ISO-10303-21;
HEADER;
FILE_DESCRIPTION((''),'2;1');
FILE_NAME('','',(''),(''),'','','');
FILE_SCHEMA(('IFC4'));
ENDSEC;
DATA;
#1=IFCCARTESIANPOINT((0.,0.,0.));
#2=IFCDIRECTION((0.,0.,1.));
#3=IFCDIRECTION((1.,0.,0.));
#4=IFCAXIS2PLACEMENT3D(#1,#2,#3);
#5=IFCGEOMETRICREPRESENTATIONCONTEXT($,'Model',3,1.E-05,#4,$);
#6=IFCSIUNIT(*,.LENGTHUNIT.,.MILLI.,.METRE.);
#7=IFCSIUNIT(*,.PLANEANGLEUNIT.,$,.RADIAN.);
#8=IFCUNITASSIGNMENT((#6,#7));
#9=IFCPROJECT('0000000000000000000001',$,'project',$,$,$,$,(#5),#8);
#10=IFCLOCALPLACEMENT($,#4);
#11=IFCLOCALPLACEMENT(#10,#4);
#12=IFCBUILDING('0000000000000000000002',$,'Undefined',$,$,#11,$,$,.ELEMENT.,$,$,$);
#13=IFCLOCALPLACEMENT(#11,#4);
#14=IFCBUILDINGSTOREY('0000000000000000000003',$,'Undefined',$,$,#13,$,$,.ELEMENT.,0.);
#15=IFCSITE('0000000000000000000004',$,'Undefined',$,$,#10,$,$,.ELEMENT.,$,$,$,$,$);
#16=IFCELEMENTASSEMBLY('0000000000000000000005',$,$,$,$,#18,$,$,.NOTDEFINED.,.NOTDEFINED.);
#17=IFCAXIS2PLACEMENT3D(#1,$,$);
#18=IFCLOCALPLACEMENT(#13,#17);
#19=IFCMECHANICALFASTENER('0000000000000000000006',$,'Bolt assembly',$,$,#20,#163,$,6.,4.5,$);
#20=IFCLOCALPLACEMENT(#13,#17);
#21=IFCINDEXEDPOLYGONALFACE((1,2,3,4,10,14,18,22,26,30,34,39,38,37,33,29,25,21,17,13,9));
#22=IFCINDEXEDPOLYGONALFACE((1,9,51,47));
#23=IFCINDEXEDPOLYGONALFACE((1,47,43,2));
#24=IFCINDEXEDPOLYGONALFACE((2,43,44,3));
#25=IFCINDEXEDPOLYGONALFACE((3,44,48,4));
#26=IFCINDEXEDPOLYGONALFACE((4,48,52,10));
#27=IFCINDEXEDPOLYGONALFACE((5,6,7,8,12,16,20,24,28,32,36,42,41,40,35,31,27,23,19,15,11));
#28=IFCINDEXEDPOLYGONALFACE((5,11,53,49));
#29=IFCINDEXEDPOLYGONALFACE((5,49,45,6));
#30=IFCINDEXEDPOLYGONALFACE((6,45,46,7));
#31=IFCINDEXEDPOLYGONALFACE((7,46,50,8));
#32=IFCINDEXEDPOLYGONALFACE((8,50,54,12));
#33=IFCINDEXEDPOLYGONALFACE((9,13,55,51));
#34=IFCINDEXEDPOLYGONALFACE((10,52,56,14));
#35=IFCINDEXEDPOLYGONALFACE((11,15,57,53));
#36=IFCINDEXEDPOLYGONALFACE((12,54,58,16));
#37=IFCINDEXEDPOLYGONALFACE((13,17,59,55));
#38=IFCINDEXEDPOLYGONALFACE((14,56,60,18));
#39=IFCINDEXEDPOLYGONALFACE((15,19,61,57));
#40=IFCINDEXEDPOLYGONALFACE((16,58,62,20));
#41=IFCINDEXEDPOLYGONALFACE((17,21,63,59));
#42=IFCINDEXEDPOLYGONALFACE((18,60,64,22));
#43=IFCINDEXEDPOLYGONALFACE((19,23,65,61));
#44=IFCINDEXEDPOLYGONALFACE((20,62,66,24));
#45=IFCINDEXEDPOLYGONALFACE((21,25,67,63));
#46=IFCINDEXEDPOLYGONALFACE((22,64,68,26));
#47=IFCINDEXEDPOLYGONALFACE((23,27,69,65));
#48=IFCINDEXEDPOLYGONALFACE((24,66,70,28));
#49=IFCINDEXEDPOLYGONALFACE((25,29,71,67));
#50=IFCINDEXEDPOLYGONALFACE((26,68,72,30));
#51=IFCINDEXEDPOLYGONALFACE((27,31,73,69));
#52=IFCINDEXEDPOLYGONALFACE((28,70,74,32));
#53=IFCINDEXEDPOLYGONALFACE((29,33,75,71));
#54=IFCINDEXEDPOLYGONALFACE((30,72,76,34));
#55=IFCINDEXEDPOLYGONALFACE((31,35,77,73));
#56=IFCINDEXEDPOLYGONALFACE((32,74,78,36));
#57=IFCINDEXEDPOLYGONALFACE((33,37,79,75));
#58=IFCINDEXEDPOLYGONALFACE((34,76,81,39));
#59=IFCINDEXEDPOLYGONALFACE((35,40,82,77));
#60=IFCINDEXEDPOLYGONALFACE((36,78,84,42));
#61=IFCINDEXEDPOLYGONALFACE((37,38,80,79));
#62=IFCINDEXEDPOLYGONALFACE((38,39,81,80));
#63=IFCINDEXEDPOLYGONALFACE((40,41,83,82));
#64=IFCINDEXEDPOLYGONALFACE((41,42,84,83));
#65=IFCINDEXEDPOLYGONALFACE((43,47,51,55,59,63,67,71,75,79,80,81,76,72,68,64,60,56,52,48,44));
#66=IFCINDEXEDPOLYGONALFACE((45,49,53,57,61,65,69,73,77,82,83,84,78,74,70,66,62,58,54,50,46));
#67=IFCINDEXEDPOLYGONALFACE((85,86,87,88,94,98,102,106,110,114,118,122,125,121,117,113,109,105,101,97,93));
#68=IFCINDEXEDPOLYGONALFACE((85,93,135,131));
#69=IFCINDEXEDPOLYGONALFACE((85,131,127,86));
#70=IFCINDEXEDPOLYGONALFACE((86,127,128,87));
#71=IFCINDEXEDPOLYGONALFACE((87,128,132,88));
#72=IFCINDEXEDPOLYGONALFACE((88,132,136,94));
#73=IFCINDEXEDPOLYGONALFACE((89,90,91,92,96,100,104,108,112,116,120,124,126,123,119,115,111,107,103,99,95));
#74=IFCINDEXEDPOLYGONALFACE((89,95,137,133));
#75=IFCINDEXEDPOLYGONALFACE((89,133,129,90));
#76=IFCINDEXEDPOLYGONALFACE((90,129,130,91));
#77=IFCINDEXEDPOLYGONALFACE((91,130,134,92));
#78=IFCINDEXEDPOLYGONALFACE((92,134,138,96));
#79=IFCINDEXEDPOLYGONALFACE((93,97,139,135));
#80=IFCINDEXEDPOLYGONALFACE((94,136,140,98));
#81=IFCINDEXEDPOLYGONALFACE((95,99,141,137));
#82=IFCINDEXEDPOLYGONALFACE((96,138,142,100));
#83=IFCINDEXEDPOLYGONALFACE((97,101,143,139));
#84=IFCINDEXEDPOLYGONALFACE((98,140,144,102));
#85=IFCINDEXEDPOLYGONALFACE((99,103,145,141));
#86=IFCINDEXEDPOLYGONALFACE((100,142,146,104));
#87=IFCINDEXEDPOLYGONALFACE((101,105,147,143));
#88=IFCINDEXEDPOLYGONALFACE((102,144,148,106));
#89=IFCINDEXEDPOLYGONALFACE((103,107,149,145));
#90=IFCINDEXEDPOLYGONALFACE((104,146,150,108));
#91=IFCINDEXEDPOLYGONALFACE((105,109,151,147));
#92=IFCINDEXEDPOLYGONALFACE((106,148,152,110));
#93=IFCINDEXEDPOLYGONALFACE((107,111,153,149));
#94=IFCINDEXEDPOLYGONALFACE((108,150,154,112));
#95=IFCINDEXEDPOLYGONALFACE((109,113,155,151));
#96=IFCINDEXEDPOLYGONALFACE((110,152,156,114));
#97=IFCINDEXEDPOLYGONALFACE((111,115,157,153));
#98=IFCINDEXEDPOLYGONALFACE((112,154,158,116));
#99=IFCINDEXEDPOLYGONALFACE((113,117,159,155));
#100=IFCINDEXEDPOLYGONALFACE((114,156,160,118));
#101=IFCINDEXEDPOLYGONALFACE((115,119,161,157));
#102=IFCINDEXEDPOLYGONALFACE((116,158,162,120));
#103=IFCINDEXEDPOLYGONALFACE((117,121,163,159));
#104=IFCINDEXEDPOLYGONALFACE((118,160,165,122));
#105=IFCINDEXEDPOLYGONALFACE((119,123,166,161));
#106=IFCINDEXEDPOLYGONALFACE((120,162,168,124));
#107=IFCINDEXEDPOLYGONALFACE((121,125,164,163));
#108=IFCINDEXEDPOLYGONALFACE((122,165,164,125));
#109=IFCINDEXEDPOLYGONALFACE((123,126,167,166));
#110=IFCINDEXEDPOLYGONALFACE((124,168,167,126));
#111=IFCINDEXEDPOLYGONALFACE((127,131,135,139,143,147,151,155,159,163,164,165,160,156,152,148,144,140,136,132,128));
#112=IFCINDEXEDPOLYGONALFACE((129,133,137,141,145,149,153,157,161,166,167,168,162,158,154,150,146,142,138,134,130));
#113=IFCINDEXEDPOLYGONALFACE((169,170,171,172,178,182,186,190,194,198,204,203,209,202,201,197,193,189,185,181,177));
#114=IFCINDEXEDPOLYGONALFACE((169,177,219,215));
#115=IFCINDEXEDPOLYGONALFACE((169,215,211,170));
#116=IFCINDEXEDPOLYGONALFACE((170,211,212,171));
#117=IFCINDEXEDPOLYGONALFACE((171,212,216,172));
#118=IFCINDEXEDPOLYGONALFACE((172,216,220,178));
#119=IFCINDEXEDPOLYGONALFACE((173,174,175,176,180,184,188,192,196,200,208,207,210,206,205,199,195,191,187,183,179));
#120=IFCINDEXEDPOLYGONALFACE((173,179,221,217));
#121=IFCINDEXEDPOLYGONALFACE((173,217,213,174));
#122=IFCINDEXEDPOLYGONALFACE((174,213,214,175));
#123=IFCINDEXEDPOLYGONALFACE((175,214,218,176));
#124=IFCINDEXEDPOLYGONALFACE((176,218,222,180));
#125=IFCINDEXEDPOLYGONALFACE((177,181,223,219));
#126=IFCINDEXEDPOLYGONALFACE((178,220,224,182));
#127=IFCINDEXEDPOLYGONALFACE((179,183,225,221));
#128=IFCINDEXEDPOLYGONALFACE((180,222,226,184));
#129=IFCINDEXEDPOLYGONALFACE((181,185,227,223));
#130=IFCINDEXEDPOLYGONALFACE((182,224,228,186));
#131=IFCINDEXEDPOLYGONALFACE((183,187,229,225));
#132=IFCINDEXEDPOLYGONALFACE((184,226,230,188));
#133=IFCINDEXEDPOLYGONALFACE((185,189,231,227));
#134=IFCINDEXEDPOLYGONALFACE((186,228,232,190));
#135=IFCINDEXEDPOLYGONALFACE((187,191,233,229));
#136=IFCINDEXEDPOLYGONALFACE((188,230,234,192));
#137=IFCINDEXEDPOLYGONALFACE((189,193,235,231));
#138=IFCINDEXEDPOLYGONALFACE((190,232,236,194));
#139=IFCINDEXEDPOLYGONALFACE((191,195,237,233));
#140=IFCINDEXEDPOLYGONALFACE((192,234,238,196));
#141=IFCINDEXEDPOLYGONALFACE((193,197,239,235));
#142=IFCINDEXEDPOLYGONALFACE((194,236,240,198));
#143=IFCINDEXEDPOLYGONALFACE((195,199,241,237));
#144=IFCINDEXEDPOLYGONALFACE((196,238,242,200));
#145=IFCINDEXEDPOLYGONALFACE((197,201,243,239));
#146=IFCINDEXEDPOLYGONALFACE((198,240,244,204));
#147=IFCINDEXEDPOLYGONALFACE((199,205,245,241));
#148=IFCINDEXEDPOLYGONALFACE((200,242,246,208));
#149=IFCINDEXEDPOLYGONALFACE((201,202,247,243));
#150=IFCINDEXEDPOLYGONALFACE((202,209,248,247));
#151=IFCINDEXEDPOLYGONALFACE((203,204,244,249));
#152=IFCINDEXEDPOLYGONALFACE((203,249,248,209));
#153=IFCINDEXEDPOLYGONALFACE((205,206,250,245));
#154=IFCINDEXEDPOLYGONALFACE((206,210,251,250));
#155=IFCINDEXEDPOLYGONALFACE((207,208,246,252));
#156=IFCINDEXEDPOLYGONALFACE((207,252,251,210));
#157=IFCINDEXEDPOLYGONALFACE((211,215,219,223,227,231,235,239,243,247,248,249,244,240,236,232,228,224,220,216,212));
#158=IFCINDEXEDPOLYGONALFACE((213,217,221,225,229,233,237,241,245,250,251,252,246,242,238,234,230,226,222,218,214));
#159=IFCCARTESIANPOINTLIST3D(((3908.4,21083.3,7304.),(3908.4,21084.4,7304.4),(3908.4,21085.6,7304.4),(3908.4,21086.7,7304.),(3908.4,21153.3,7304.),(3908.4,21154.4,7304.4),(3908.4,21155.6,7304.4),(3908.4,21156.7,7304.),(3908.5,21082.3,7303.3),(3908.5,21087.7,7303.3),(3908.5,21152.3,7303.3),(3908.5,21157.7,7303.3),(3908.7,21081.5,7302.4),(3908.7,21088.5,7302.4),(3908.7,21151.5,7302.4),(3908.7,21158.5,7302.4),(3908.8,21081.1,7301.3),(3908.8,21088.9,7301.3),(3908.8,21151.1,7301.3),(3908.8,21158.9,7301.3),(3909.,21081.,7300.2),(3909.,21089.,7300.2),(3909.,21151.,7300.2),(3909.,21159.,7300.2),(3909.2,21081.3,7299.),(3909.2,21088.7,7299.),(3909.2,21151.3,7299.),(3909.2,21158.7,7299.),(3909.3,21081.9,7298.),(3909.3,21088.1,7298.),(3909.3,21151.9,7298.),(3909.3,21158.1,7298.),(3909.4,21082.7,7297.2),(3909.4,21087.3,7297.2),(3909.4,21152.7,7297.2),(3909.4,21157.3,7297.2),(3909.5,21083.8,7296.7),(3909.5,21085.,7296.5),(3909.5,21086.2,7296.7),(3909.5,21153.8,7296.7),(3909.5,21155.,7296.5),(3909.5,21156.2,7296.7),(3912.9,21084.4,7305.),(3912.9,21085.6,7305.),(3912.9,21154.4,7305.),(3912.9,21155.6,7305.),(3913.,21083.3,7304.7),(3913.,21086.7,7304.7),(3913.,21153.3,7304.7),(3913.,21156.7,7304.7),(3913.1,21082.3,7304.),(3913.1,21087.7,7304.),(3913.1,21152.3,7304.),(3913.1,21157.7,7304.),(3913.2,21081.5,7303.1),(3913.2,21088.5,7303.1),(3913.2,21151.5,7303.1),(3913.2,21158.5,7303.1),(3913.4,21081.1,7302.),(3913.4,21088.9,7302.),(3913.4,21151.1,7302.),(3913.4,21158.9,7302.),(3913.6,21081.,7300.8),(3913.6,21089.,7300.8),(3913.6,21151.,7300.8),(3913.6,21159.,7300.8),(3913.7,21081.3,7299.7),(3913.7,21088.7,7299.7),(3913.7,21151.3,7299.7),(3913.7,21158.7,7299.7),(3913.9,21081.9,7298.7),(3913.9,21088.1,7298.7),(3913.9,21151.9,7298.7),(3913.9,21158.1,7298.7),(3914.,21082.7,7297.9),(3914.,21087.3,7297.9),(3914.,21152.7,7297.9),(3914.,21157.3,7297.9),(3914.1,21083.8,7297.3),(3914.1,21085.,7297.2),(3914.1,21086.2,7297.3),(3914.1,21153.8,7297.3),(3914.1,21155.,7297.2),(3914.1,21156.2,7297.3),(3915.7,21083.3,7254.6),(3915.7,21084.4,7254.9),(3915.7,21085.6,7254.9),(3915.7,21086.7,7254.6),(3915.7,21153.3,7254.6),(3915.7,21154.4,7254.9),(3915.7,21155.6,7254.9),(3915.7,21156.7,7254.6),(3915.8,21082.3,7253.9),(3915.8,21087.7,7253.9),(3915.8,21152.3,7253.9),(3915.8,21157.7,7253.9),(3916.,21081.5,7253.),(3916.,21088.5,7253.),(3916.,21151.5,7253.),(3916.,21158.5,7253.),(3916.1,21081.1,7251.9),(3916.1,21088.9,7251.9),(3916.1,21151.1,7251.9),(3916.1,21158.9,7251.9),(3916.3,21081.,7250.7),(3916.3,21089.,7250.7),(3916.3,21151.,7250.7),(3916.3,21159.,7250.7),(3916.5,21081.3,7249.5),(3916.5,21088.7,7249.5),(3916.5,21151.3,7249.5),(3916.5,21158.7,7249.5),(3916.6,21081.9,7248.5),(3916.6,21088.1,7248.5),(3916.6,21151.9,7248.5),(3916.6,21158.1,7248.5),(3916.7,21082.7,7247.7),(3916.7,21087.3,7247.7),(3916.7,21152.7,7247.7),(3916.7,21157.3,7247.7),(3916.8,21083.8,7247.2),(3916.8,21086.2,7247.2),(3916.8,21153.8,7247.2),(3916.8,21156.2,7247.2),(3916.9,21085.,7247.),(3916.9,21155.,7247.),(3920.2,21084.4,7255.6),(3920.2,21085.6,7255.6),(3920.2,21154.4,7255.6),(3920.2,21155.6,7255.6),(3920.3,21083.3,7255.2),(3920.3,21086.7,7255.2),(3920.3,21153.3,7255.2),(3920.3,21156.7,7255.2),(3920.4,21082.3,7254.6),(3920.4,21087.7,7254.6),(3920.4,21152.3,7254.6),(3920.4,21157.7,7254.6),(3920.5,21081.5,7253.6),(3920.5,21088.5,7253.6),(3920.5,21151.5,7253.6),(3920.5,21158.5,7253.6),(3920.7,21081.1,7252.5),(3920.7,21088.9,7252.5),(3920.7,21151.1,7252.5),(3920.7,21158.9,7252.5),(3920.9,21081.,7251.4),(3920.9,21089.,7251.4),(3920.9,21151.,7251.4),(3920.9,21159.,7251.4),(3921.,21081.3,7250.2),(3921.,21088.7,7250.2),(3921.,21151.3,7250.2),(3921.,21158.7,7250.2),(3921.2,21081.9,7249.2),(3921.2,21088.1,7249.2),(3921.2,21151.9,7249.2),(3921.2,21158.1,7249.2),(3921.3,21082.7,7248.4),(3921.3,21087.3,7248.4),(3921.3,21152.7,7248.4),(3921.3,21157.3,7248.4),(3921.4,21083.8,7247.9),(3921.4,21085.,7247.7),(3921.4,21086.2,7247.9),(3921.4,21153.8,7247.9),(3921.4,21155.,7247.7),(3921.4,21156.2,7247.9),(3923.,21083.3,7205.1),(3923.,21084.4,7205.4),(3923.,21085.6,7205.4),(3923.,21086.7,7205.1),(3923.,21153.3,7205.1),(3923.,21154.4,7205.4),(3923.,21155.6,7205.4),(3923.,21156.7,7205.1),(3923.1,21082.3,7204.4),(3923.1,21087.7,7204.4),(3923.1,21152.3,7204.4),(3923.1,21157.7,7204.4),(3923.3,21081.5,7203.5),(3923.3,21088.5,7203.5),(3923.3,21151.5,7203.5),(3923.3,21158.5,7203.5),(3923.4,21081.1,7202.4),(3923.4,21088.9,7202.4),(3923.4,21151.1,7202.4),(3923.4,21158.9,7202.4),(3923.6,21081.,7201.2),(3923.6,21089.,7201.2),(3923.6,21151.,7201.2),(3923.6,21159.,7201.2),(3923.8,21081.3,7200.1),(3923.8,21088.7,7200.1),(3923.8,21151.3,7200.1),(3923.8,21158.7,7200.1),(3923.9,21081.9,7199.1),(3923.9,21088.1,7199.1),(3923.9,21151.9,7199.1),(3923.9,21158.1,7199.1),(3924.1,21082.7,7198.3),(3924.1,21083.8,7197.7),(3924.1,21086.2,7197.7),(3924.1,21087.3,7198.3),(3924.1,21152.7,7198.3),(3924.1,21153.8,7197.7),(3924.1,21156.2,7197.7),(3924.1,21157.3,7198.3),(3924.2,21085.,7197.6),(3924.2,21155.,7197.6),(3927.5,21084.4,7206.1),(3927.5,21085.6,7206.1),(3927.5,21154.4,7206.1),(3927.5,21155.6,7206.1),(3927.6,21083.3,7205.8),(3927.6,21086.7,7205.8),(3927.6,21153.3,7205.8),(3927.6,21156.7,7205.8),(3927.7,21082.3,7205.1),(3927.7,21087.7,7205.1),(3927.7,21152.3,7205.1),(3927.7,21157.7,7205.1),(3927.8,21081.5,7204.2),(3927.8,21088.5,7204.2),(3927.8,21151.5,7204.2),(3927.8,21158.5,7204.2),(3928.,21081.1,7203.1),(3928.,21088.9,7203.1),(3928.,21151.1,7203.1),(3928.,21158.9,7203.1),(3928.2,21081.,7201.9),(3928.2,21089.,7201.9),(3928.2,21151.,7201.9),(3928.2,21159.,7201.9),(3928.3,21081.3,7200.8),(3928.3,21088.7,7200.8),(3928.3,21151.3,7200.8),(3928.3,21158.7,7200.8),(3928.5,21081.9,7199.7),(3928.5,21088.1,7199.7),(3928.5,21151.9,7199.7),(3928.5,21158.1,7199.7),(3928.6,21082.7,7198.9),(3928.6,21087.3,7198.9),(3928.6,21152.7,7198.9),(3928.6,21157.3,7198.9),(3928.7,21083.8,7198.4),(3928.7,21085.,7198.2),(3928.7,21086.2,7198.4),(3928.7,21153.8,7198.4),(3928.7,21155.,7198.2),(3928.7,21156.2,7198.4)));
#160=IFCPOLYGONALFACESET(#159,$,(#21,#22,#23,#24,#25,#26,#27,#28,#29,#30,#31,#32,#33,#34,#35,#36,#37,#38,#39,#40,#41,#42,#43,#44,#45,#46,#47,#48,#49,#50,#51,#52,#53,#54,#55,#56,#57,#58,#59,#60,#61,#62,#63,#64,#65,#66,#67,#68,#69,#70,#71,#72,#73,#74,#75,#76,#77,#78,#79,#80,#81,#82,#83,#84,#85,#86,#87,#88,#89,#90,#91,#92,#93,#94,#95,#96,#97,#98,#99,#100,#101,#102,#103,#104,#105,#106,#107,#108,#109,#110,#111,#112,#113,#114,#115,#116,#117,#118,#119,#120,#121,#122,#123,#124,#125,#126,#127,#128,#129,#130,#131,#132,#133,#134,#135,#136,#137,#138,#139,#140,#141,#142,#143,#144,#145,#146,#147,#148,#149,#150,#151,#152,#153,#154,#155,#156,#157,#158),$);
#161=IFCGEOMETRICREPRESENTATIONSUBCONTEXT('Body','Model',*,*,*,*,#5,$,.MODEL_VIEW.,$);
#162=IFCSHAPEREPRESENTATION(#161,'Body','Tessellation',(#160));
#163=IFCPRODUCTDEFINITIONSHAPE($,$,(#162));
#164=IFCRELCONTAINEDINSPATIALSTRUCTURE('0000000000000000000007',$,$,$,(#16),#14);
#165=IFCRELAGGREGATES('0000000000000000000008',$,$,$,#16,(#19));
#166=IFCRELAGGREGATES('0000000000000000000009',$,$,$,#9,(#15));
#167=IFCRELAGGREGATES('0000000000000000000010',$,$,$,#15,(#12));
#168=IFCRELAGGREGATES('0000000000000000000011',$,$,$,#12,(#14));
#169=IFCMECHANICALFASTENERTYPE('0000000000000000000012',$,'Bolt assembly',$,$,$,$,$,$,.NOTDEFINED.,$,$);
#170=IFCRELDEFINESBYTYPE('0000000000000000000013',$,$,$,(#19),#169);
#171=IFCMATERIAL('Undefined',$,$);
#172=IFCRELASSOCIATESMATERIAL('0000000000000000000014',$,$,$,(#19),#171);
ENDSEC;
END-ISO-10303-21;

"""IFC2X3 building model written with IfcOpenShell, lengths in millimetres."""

from ifc_helpers import new_model, si_unit, frame, origin_with_axes, origin_2d_with_axis, place, context, subcontext, project, spatial, circle, extrude, source, transform, mapped, material, type_object, element, aggregate, save


model = new_model("IFC2X3")

# Units and contexts
model_context = context("Model", 3, precision=1e-05, world=origin_with_axes())
body_context = subcontext(model_context, "Body", "Model", "MODEL_VIEW")
ifc_project = project(units=[si_unit("LENGTHUNIT", "METRE", prefix="MILLI"), si_unit("PLANEANGLEUNIT", "RADIAN")], contexts=[model_context])

# Site, building, storey
site_placement = place(None, origin_with_axes())
site = spatial("IfcSite", under=ifc_project, at=site_placement, Name="Undefined", CompositionType="ELEMENT")
building_placement = place(site_placement, origin_with_axes())
building = spatial("IfcBuilding", under=site, at=building_placement, Name="Undefined", CompositionType="ELEMENT")
storey_placement = place(building_placement, origin_with_axes())
storey = spatial("IfcBuildingStorey", under=building, at=storey_placement, Name="Undefined", CompositionType="ELEMENT", Elevation=0.0)

# Element assembly
assembly_1_placement = place(storey_placement, origin_with_axes())
assembly_1 = element("IfcElementAssembly", 1, at=assembly_1_placement, inside=storey, AssemblyPlace="NOTDEFINED", PredefinedType="NOTDEFINED")

# Mechanical fastener
ifc_material_1 = material(Name="Undefined")
mechanical_fastener_type = type_object("IfcMechanicalFastenerType", Name="Bolt assembly")
shared_shape_1 = source(origin_with_axes(), body_context, "Body", "SweptSolid", [
    extrude(circle(Radius=4.0, at=origin_2d_with_axis()), frame((0.0, 0.0, 0.0), z_axis=(0.0, 1.0, 0.0), x_axis=(1.0, 0.0, 0.0)), (0.0, 0.0, 1.0), 4.6),
])
mechanical_fastener_1_placement = place(assembly_1_placement, frame((3909.0, 21120.0, 7300.4), z_axis=(0.0, -1.0, 0.0), x_axis=(0.146203, 0.0, -0.989255)))
mechanical_fastener_1 = element("IfcMechanicalFastener", 2, at=mechanical_fastener_1_placement, type_object=mechanical_fastener_type, material=ifc_material_1, Name="Bolt assembly", NominalDiameter=6.0, NominalLength=4.5, context=body_context, shape_type="MappedRepresentation", body=[
    mapped(shared_shape_1, transform((0.0, 0.0, -35.0))),
    mapped(shared_shape_1, transform((50.0, 0.0, -35.0))),
    mapped(shared_shape_1, transform((100.0, 0.0, -35.0))),
    mapped(shared_shape_1, transform((0.0, 0.0, 35.0))),
    mapped(shared_shape_1, transform((50.0, 0.0, 35.0))),
    mapped(shared_shape_1, transform((100.0, 0.0, 35.0))),
])

aggregate(assembly_1, [mechanical_fastener_1])

save(model, "model.ifc")
